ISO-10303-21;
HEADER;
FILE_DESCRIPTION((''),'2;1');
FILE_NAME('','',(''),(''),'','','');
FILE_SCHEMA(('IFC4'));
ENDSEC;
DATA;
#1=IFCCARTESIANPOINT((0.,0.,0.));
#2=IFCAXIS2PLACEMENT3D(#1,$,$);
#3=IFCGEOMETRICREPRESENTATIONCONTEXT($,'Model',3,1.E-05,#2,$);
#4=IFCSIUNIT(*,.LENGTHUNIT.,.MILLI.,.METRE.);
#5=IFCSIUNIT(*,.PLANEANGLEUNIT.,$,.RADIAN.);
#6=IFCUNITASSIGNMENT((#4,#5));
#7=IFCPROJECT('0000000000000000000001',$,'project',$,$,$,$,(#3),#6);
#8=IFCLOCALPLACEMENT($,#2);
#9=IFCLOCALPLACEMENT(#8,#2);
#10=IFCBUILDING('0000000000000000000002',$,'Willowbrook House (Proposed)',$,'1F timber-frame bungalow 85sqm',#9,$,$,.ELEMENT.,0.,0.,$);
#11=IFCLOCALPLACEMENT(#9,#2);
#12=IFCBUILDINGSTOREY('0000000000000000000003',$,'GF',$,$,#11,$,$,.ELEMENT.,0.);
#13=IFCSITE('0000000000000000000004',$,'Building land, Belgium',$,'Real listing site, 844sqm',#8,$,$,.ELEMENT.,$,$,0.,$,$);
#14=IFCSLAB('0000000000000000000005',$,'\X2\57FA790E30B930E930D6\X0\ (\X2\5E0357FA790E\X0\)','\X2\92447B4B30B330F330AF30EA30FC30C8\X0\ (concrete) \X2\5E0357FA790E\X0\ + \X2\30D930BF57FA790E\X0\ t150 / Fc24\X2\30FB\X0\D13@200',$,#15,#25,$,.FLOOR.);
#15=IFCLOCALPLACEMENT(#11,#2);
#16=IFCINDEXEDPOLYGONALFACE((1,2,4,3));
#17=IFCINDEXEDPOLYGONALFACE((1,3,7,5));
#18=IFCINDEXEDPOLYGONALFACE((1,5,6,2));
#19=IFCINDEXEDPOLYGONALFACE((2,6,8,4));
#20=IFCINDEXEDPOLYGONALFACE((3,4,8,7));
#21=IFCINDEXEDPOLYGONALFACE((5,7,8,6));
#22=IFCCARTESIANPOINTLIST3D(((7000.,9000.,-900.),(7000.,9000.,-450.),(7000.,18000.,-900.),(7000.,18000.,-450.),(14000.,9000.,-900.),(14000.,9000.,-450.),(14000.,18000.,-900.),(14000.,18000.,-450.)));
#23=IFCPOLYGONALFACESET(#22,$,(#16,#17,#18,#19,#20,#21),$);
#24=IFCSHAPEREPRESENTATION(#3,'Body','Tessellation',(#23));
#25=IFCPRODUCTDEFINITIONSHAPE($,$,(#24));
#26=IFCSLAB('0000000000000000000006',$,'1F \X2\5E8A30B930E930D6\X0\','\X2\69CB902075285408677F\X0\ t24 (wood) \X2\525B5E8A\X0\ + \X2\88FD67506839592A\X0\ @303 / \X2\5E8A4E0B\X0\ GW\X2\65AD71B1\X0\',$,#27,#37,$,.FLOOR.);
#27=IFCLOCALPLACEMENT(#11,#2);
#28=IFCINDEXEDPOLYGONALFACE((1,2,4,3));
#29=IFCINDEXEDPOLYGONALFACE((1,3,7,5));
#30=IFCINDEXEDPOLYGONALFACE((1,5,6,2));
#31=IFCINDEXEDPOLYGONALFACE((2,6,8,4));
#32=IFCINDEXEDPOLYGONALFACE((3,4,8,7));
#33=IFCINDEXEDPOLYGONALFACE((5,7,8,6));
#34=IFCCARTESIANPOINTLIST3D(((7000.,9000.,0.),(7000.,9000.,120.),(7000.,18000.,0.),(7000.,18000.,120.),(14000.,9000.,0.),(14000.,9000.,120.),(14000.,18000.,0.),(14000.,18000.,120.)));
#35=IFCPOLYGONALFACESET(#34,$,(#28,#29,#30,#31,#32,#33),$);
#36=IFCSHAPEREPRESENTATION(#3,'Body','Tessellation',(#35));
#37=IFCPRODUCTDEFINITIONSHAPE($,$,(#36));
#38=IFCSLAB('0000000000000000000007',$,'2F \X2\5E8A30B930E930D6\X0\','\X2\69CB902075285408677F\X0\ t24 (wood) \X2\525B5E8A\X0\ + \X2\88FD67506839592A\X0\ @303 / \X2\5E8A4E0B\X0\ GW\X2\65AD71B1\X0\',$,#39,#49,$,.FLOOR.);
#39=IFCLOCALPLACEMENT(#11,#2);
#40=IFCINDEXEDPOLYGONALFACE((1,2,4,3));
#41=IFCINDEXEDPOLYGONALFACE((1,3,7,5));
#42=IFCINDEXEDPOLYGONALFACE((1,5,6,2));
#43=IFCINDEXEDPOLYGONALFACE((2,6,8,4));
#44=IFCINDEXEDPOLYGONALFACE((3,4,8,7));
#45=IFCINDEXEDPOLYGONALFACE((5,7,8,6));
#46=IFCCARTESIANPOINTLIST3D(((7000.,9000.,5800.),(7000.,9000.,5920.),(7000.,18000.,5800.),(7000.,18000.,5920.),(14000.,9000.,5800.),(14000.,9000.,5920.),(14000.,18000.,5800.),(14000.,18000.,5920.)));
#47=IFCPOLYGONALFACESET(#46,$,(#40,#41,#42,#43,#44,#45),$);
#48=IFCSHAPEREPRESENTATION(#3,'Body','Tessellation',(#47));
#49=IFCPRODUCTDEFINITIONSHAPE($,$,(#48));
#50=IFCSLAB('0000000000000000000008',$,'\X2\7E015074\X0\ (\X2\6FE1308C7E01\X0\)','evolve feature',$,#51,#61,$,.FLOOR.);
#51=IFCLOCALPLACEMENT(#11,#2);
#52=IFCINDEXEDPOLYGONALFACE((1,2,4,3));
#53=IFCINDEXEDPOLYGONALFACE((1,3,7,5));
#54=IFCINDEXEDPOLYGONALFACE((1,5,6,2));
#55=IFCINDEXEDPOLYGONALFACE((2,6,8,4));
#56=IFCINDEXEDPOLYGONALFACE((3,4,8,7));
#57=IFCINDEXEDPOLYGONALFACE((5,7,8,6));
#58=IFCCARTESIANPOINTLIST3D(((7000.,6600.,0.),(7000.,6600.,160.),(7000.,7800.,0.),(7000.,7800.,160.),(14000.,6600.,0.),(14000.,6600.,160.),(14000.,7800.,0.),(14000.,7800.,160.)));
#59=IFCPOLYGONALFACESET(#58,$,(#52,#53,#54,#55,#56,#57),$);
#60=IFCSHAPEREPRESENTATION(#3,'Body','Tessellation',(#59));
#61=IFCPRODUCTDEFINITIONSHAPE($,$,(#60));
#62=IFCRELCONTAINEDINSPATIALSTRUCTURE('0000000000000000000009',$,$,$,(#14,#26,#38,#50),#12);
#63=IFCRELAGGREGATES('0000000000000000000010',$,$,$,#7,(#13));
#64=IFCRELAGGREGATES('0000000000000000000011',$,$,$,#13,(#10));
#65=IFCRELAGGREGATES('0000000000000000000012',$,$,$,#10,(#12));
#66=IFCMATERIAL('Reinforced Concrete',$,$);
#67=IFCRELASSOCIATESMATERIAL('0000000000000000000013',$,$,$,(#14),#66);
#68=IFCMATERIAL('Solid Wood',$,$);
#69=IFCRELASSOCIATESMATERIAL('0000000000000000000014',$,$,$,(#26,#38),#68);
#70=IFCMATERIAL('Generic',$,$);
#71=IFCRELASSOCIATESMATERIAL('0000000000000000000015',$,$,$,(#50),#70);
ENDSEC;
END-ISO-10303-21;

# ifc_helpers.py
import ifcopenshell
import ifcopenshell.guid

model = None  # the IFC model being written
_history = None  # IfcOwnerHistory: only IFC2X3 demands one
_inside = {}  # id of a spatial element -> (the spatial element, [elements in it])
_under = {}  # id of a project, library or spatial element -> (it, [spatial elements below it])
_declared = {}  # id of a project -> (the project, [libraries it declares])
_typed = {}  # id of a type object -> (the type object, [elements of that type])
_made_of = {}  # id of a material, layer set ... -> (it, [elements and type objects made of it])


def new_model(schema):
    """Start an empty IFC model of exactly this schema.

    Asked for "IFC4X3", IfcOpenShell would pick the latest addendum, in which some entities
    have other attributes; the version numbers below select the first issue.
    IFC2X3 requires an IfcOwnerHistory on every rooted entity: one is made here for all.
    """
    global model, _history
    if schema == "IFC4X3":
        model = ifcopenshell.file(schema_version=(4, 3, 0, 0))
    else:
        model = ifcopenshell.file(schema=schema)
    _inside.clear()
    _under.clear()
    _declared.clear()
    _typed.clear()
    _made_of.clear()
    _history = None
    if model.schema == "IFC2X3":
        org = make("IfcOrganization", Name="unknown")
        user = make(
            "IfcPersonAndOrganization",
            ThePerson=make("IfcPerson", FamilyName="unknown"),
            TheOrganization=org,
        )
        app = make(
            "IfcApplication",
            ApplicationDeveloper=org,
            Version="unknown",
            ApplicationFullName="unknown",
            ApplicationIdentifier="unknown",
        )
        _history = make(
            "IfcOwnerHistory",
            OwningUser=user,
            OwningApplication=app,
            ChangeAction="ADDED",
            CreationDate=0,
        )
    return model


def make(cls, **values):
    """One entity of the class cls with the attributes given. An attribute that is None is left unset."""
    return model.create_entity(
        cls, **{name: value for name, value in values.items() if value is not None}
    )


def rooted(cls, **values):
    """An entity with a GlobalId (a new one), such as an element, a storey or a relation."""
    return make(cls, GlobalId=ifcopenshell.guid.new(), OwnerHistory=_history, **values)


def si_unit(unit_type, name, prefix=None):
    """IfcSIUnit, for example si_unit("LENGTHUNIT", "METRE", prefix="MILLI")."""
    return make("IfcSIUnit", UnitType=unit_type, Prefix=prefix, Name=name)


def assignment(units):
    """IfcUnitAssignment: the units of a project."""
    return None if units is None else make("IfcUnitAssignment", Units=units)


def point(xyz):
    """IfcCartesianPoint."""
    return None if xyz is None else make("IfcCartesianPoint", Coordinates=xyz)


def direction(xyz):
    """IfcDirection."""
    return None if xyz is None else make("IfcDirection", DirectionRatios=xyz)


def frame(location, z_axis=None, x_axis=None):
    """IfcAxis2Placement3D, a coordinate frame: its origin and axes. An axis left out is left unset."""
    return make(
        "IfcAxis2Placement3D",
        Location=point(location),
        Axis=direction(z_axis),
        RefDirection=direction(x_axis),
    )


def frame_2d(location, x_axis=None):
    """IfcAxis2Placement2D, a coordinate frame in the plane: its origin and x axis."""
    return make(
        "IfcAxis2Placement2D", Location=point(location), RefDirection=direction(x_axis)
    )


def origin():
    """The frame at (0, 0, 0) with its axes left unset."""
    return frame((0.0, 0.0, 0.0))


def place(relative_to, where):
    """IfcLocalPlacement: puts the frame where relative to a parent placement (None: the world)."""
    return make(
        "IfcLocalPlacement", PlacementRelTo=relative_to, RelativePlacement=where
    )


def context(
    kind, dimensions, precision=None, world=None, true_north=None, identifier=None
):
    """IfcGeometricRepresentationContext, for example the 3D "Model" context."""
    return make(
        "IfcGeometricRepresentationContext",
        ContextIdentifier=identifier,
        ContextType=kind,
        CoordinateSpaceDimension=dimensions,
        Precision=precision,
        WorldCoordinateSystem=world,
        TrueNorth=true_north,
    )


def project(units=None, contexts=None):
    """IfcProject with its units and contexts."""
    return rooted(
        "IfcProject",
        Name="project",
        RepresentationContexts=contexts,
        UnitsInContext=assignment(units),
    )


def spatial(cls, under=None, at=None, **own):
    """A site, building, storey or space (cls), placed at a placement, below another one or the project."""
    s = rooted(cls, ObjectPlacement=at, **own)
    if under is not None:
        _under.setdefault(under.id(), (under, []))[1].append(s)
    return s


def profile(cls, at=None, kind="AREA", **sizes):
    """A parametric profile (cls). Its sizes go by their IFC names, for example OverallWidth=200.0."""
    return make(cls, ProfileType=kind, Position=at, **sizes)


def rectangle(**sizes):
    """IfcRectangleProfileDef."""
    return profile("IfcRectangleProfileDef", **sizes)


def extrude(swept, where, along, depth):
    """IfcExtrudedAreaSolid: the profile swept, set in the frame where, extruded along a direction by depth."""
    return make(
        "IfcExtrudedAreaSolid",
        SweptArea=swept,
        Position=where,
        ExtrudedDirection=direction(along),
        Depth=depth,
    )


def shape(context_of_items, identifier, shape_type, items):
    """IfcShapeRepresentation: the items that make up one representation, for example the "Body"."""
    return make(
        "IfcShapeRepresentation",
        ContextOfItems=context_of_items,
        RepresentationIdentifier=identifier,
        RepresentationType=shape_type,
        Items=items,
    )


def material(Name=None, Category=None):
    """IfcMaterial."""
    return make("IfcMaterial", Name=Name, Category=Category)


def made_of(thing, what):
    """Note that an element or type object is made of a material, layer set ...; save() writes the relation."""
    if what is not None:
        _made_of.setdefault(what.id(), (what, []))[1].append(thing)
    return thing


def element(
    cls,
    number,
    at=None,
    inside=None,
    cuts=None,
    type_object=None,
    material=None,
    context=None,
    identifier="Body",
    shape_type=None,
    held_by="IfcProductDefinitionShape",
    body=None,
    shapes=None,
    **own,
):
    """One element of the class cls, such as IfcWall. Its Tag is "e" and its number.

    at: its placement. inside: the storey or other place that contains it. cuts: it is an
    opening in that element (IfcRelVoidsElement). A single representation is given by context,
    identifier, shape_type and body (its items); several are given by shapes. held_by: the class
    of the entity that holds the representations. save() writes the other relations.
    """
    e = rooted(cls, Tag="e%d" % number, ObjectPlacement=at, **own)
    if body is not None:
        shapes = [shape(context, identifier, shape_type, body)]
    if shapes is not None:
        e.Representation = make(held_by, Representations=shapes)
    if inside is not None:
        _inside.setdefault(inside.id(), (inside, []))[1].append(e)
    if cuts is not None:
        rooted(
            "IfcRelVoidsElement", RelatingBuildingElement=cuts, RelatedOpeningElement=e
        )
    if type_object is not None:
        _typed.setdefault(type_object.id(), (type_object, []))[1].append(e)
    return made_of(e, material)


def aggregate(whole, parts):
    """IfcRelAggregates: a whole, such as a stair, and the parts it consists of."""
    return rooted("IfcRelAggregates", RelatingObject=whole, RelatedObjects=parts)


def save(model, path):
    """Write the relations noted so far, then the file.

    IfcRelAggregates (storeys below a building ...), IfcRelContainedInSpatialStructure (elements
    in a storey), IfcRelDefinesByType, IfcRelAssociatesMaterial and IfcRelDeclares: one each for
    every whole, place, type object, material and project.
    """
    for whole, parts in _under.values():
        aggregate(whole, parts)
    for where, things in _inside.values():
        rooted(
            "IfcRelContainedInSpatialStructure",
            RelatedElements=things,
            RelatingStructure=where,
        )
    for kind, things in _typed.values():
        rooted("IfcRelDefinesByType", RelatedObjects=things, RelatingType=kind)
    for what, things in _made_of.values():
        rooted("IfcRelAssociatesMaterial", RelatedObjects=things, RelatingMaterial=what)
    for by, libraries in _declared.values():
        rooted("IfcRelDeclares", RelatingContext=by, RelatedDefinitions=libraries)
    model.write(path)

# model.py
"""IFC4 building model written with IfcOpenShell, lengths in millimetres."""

from ifc_helpers import new_model, si_unit, frame, frame_2d, origin, place, context, project, spatial, rectangle, extrude, material, element, save


model = new_model("IFC4")

# Units and contexts
model_context = context("Model", 3, precision=1e-05, world=origin())
ifc_project = project(units=[si_unit("LENGTHUNIT", "METRE", prefix="MILLI"), si_unit("PLANEANGLEUNIT", "RADIAN")], contexts=[model_context])

# Site, building, storey
site_placement = place(None, origin())
site = spatial("IfcSite", under=ifc_project, at=site_placement, Name="Building land, Belgium", ObjectType="Real listing site, 844sqm", CompositionType="ELEMENT", RefElevation=0.0)
building_placement = place(site_placement, origin())
building = spatial("IfcBuilding", under=site, at=building_placement, Name="Willowbrook House (Proposed)", ObjectType="1F timber-frame bungalow 85sqm", CompositionType="ELEMENT", ElevationOfRefHeight=0.0, ElevationOfTerrain=0.0)
storey_placement = place(building_placement, origin())
storey = spatial("IfcBuildingStorey", under=building, at=storey_placement, Name="GF", CompositionType="ELEMENT", Elevation=0.0)

# Slabs
ifc_material_1 = material(Name="Reinforced Concrete")
slab_1_placement = place(storey_placement, frame((3500.0, 4500.0, -450.0)))
element("IfcSlab", 1, at=slab_1_placement, inside=storey, material=ifc_material_1, Name="基礎スラブ (布基礎)", Description="鉄筋コンクリート (concrete) 布基礎 + ベタ基礎 t150 / Fc24・D13@200", PredefinedType="FLOOR", context=model_context, shape_type="SweptSolid", body=[
    extrude(rectangle(XDim=7000.0, YDim=9000.0, at=frame_2d((3500.0, 4500.0))), frame((3500.0, 4500.0, -450.0)), (0.0, 0.0, 1.0), 450.0),
])
ifc_material_2 = material(Name="Solid Wood")
slab_2_placement = place(storey_placement, frame((3500.0, 4500.0, 0.0)))
element("IfcSlab", 2, at=slab_2_placement, inside=storey, material=ifc_material_2, Name="1F 床スラブ", Description="構造用合板 t24 (wood) 剛床 + 製材根太 @303 / 床下 GW断熱", PredefinedType="FLOOR", context=model_context, shape_type="SweptSolid", body=[
    extrude(rectangle(XDim=7000.0, YDim=9000.0, at=frame_2d((3500.0, 4500.0))), frame((3500.0, 4500.0, 0.0)), (0.0, 0.0, 1.0), 120.0),
])
slab_3_placement = place(storey_placement, frame((3500.0, 4500.0, 2900.0)))
element("IfcSlab", 3, at=slab_3_placement, inside=storey, material=ifc_material_2, Name="2F 床スラブ", Description="構造用合板 t24 (wood) 剛床 + 製材根太 @303 / 床下 GW断熱", PredefinedType="FLOOR", context=model_context, shape_type="SweptSolid", body=[
    extrude(rectangle(XDim=7000.0, YDim=9000.0, at=frame_2d((3500.0, 4500.0))), frame((3500.0, 4500.0, 2900.0)), (0.0, 0.0, 1.0), 120.0),
])
ifc_material_3 = material(Name="Generic")
slab_4_placement = place(storey_placement, frame((3500.0, 3300.0, 0.0)))
element("IfcSlab", 4, at=slab_4_placement, inside=storey, material=ifc_material_3, Name="縁側 (濡れ縁)", Description="evolve feature", PredefinedType="FLOOR", context=model_context, shape_type="SweptSolid", body=[
    extrude(rectangle(XDim=7000.0, YDim=1200.0, at=frame_2d((3500.0, 600.0))), frame((3500.0, 3300.0, 0.0)), (0.0, 0.0, 1.0), 160.0),
])

save(model, "model.ifc")
